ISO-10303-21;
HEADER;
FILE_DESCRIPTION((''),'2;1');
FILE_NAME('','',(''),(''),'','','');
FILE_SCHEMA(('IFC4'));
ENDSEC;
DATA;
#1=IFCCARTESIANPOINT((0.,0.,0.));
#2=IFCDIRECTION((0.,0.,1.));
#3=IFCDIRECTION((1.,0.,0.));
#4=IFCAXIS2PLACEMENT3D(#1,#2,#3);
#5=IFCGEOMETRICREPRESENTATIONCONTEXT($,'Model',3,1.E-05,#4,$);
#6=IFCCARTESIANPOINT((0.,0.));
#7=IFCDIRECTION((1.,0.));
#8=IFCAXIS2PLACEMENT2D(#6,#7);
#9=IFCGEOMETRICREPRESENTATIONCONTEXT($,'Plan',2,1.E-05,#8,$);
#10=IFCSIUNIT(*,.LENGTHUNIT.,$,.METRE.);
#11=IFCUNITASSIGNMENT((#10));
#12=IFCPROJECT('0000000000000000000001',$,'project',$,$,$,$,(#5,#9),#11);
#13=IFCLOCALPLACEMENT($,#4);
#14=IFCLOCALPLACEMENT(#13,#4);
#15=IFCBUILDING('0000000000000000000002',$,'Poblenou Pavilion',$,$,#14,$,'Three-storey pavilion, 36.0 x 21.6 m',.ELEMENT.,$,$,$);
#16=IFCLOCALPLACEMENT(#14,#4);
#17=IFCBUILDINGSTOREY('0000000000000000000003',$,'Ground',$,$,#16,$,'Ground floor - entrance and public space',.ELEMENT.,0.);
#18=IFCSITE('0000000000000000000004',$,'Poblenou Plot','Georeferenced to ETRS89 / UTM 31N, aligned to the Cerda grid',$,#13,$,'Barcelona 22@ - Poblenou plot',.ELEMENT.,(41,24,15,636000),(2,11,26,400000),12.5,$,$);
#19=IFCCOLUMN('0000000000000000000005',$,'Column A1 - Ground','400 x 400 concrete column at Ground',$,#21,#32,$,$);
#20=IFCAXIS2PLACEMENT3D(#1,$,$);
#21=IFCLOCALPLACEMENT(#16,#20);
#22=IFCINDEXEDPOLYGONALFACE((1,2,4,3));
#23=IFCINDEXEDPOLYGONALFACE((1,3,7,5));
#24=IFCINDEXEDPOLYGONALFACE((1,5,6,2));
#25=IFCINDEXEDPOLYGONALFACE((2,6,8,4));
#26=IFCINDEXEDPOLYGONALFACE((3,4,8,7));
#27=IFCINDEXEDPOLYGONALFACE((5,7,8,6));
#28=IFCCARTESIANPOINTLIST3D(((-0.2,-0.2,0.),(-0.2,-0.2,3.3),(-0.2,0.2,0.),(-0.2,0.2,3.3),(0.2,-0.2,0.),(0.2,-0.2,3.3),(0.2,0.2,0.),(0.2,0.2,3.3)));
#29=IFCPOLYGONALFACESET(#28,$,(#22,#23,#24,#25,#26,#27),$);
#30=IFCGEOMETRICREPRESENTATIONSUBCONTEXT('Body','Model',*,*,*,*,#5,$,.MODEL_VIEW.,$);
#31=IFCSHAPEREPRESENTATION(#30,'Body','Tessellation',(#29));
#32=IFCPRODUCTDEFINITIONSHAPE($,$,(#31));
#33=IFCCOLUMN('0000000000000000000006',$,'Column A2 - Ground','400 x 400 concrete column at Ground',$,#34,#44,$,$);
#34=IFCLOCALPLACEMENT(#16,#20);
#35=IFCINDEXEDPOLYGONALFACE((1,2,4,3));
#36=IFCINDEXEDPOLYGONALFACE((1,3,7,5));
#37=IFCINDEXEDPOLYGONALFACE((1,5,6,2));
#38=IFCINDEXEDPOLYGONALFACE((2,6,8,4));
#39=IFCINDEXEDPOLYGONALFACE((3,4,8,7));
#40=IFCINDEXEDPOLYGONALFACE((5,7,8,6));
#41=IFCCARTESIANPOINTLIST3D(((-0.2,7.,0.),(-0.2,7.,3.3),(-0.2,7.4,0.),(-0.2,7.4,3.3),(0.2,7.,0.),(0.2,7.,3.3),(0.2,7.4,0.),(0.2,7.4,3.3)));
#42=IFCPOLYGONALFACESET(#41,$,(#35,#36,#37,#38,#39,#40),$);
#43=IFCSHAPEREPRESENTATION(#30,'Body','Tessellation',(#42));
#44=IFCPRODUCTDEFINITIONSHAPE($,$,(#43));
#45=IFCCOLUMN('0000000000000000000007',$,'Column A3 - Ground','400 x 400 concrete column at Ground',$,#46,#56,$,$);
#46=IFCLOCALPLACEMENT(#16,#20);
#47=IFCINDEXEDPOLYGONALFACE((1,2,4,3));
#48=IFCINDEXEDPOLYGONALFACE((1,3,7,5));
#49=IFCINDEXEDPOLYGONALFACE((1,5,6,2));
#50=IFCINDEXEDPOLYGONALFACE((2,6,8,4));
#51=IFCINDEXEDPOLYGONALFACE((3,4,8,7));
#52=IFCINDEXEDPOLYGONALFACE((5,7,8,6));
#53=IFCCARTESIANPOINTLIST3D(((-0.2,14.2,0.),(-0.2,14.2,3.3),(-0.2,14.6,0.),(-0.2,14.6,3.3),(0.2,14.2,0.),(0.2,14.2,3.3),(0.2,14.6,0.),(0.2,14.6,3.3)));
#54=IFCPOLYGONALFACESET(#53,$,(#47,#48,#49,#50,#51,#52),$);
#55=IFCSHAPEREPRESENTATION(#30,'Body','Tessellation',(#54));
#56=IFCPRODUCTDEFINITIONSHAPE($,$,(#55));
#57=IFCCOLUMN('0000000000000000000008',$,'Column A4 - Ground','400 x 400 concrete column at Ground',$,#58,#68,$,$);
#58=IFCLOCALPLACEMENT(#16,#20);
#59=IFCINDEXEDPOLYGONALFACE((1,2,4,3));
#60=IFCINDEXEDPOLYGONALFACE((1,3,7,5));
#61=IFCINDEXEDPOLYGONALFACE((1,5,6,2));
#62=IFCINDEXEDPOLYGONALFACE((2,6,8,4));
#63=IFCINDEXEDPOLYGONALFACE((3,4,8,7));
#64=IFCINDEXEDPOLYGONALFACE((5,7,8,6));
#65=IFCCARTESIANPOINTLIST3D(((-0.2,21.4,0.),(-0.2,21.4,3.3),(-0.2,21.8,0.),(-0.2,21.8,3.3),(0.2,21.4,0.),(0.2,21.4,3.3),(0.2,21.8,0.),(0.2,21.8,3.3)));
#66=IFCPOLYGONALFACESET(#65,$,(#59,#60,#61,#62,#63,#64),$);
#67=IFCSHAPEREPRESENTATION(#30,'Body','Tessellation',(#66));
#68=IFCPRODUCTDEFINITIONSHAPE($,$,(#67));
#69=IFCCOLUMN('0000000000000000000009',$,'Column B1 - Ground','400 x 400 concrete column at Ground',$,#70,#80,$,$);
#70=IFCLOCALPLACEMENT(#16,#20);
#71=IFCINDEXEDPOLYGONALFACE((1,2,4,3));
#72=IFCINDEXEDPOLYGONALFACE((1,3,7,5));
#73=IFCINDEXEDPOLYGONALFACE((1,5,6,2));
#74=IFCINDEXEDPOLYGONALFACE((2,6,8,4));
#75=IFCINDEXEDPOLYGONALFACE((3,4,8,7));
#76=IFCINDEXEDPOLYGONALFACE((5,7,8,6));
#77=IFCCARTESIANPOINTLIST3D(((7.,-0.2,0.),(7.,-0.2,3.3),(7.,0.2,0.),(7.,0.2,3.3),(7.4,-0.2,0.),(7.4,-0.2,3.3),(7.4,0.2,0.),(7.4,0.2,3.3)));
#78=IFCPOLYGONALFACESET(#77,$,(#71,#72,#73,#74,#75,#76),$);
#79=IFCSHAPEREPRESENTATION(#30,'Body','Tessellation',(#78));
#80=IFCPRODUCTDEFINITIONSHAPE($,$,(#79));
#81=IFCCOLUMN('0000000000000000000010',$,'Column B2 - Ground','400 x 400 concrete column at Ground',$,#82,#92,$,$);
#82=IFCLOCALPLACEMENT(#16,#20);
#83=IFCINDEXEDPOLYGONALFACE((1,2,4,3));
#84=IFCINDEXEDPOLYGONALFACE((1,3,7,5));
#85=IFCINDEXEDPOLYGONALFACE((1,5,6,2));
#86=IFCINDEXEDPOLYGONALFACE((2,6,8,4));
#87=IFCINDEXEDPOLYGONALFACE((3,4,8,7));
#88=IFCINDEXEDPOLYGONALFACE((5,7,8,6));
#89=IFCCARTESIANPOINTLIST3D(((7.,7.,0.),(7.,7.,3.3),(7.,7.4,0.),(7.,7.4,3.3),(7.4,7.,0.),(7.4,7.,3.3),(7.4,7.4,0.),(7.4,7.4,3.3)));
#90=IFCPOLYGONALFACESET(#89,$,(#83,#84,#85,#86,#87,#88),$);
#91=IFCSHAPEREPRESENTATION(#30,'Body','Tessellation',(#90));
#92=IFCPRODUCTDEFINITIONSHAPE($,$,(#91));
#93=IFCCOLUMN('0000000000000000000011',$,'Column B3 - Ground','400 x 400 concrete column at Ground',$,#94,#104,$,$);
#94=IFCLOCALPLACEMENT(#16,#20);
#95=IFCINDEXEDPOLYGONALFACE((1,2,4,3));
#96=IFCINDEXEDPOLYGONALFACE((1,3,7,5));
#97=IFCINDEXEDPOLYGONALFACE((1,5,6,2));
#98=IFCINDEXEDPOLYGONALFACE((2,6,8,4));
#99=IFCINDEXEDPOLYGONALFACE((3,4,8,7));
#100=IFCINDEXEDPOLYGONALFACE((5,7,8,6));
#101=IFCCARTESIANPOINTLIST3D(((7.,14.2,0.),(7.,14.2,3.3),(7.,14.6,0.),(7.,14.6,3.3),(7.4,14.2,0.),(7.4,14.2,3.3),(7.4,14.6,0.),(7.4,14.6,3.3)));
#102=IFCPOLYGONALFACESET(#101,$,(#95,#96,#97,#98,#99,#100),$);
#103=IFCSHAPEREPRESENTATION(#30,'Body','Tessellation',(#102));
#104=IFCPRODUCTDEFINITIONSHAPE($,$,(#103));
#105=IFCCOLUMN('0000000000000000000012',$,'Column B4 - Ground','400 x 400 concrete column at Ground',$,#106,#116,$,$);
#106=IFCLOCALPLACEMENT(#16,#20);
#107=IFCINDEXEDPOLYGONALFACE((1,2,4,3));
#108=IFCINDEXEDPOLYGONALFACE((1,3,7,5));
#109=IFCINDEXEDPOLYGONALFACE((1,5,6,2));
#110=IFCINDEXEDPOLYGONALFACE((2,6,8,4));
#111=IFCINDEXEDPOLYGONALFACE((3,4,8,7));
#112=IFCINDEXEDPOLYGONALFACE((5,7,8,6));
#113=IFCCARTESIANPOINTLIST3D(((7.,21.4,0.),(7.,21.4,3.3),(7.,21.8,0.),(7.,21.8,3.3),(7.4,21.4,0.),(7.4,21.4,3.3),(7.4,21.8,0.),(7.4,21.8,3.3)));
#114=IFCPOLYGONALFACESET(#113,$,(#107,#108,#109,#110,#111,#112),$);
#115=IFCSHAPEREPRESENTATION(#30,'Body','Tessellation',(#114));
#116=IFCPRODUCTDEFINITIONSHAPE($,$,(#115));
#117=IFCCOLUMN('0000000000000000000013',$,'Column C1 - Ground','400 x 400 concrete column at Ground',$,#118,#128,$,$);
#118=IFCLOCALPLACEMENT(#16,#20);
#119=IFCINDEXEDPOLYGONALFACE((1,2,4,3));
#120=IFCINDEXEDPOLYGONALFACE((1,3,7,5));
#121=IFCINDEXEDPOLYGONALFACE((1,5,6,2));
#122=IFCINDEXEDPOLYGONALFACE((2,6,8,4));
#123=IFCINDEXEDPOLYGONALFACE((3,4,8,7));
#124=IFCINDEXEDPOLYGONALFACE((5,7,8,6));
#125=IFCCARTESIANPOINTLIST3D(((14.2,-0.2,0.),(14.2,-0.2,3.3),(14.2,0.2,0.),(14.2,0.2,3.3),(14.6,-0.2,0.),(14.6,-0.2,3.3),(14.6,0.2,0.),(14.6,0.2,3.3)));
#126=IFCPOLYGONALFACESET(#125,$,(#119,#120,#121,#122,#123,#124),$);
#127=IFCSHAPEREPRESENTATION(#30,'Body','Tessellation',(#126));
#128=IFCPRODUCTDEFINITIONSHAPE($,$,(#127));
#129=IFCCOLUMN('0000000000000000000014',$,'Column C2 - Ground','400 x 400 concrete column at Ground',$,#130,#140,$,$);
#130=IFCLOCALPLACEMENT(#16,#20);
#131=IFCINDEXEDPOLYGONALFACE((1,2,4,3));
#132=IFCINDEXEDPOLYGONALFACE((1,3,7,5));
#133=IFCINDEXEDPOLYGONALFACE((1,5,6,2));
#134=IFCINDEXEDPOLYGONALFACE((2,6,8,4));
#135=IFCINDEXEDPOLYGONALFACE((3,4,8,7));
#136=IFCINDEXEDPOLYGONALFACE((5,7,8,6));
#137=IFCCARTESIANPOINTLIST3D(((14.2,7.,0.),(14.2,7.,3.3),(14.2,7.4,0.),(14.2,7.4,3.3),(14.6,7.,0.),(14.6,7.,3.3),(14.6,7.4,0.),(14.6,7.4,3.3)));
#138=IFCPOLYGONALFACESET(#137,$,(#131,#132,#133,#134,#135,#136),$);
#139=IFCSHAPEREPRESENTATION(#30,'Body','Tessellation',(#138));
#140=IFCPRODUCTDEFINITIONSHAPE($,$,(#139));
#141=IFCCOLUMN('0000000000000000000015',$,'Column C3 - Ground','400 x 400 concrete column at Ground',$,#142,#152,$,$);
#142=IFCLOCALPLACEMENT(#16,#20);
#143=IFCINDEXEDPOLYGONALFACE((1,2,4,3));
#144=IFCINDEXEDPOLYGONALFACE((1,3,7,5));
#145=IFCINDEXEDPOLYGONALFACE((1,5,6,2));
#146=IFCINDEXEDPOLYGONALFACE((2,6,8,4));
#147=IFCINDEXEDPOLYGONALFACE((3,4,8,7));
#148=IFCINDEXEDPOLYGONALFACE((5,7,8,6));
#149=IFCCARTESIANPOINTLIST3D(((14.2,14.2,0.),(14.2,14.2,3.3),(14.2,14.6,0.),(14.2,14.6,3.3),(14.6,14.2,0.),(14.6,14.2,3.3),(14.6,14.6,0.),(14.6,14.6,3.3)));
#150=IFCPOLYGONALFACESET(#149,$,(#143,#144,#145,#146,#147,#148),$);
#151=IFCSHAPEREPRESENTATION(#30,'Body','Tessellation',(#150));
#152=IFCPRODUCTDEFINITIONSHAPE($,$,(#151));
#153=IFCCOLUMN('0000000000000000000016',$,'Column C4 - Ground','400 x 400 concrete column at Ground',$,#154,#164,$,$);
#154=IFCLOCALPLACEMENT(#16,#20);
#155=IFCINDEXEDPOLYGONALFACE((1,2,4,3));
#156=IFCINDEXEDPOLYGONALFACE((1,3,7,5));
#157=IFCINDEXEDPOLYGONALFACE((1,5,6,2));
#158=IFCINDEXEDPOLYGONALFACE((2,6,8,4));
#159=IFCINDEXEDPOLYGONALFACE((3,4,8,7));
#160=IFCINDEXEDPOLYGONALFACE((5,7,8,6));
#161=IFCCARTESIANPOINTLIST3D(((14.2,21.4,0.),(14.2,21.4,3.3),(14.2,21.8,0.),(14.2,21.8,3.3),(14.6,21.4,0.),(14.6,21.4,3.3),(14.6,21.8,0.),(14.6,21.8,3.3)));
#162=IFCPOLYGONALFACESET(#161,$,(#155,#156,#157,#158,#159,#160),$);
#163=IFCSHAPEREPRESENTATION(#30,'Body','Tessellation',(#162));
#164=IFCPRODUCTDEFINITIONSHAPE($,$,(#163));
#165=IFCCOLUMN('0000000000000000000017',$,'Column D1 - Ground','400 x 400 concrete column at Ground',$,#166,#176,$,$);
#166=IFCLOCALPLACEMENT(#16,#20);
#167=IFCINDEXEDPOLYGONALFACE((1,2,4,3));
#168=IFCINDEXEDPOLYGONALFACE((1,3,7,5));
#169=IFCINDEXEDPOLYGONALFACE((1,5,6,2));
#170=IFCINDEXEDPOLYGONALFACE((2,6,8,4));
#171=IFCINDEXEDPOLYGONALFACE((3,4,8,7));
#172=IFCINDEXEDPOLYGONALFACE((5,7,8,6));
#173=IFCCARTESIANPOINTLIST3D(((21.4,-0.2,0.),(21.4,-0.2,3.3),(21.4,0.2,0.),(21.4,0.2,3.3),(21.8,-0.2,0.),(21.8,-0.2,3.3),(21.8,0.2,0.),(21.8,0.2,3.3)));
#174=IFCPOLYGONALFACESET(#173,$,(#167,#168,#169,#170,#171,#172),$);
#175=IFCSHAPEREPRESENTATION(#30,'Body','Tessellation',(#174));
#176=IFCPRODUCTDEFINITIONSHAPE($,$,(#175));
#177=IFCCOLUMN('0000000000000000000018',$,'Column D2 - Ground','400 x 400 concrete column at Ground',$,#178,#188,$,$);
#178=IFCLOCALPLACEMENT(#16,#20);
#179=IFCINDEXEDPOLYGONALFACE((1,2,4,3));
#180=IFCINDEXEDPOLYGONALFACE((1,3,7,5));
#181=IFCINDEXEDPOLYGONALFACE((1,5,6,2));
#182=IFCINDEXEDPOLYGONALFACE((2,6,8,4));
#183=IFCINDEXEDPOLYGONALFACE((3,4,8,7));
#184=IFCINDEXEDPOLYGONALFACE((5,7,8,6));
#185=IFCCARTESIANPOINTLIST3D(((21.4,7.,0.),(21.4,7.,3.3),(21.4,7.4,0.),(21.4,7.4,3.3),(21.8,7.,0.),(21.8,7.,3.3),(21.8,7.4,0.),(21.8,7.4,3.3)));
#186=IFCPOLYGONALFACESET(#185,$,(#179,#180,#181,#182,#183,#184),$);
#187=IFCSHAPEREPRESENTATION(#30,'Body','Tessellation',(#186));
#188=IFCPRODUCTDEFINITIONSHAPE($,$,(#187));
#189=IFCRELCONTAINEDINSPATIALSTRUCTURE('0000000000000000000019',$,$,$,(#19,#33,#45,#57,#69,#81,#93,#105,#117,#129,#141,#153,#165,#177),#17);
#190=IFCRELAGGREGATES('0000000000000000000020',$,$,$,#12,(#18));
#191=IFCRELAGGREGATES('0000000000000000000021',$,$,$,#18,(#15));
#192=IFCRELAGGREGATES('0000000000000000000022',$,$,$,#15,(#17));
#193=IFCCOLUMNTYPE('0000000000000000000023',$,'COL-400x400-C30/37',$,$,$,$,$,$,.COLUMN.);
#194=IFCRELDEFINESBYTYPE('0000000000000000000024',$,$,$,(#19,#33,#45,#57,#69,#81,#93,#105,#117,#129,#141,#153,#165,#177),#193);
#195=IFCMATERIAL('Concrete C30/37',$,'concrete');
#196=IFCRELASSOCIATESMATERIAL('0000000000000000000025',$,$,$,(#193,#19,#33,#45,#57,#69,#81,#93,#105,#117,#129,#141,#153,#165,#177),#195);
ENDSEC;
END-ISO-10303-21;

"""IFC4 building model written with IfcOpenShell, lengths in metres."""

from ifc_helpers import new_model, si_unit, frame, origin_with_axes, origin_2d_with_axis, place, context, subcontext, project, spatial, line, indexed_curve, rectangle, outline, extrude, material, material_profile, profile_set, profile_usage, type_object, element, save


model = new_model("IFC4")

# Units and contexts
model_context = context("Model", 3, precision=1e-05, world=origin_with_axes())
plan_context = context("Plan", 2, precision=1e-05, world=origin_2d_with_axis())
body_context = subcontext(model_context, "Body", "Model", "MODEL_VIEW")
ifc_project = project(units=[si_unit("LENGTHUNIT", "METRE")], contexts=[model_context, plan_context])

# Site, building, storey
site_placement = place(None, origin_with_axes())
site = spatial("IfcSite", under=ifc_project, at=site_placement, Name="Poblenou Plot", Description="Georeferenced to ETRS89 / UTM 31N, aligned to the Cerda grid", LongName="Barcelona 22@ - Poblenou plot", CompositionType="ELEMENT", RefLatitude=(41, 24, 15, 636000), RefLongitude=(2, 11, 26, 400000), RefElevation=12.5)
building_placement = place(site_placement, origin_with_axes())
building = spatial("IfcBuilding", under=site, at=building_placement, Name="Poblenou Pavilion", LongName="Three-storey pavilion, 36.0 x 21.6 m", CompositionType="ELEMENT")
storey_placement = place(building_placement, origin_with_axes())
storey = spatial("IfcBuildingStorey", under=building, at=storey_placement, Name="Ground", LongName="Ground floor - entrance and public space", CompositionType="ELEMENT", Elevation=0.0)

# Columns
ifc_material = material(Name="Concrete C30/37", Category="concrete")
ifc_material_profile = material_profile(ifc_material, rectangle(XDim=0.4, YDim=0.4))
ifc_profile_set = profile_set([ifc_material_profile], Name="COL-400x400-C30/37")
ifc_profile_usage_1 = profile_usage(ifc_profile_set)
column_type = type_object("IfcColumnType", Name="COL-400x400-C30/37", PredefinedType="COLUMN", material=ifc_profile_set)
column_1_placement = place(storey_placement, frame((-0.2, -0.2, 0.0), z_axis=(0.0, 0.0, 1.0), x_axis=(1.0, 0.0, 0.0)))
element("IfcColumn", 1, at=column_1_placement, inside=storey, type_object=column_type, material=ifc_profile_usage_1, Name="Column A1 - Ground", Description="400 x 400 concrete column at Ground", context=body_context, shape_type="SweptSolid", body=[
    extrude(outline(indexed_curve([(0.0, 0.0), (0.4, 0.0), (0.4, 0.4), (0.0, 0.4)], segments=[line(1, 2, 3, 4, 1)])), origin_with_axes(), (0.0, 0.0, 1.0), 3.3),
])
ifc_profile_usage_2 = profile_usage(ifc_profile_set)
column_2_placement = place(storey_placement, frame((-0.2, 7.0, 0.0), z_axis=(0.0, 0.0, 1.0), x_axis=(1.0, 0.0, 0.0)))
element("IfcColumn", 2, at=column_2_placement, inside=storey, type_object=column_type, material=ifc_profile_usage_2, Name="Column A2 - Ground", Description="400 x 400 concrete column at Ground", context=body_context, shape_type="SweptSolid", body=[
    extrude(outline(indexed_curve([(0.0, 0.0), (0.4, 0.0), (0.4, 0.4), (0.0, 0.4)], segments=[line(1, 2, 3, 4, 1)])), origin_with_axes(), (0.0, 0.0, 1.0), 3.3),
])
ifc_profile_usage_3 = profile_usage(ifc_profile_set)
column_3_placement = place(storey_placement, frame((-0.2, 14.2, 0.0), z_axis=(0.0, 0.0, 1.0), x_axis=(1.0, 0.0, 0.0)))
element("IfcColumn", 3, at=column_3_placement, inside=storey, type_object=column_type, material=ifc_profile_usage_3, Name="Column A3 - Ground", Description="400 x 400 concrete column at Ground", context=body_context, shape_type="SweptSolid", body=[
    extrude(outline(indexed_curve([(0.0, 0.0), (0.4, 0.0), (0.4, 0.4), (0.0, 0.4)], segments=[line(1, 2, 3, 4, 1)])), origin_with_axes(), (0.0, 0.0, 1.0), 3.3),
])
ifc_profile_usage_4 = profile_usage(ifc_profile_set)
column_4_placement = place(storey_placement, frame((-0.2, 21.4, 0.0), z_axis=(0.0, 0.0, 1.0), x_axis=(1.0, 0.0, 0.0)))
element("IfcColumn", 4, at=column_4_placement, inside=storey, type_object=column_type, material=ifc_profile_usage_4, Name="Column A4 - Ground", Description="400 x 400 concrete column at Ground", context=body_context, shape_type="SweptSolid", body=[
    extrude(outline(indexed_curve([(0.0, 0.0), (0.4, 0.0), (0.4, 0.4), (0.0, 0.4)], segments=[line(1, 2, 3, 4, 1)])), origin_with_axes(), (0.0, 0.0, 1.0), 3.3),
])
ifc_profile_usage_5 = profile_usage(ifc_profile_set)
column_5_placement = place(storey_placement, frame((7.0, -0.2, 0.0), z_axis=(0.0, 0.0, 1.0), x_axis=(1.0, 0.0, 0.0)))
element("IfcColumn", 5, at=column_5_placement, inside=storey, type_object=column_type, material=ifc_profile_usage_5, Name="Column B1 - Ground", Description="400 x 400 concrete column at Ground", context=body_context, shape_type="SweptSolid", body=[
    extrude(outline(indexed_curve([(0.0, 0.0), (0.4, 0.0), (0.4, 0.4), (0.0, 0.4)], segments=[line(1, 2, 3, 4, 1)])), origin_with_axes(), (0.0, 0.0, 1.0), 3.3),
])
ifc_profile_usage_6 = profile_usage(ifc_profile_set)
column_6_placement = place(storey_placement, frame((7.0, 7.0, 0.0), z_axis=(0.0, 0.0, 1.0), x_axis=(1.0, 0.0, 0.0)))
element("IfcColumn", 6, at=column_6_placement, inside=storey, type_object=column_type, material=ifc_profile_usage_6, Name="Column B2 - Ground", Description="400 x 400 concrete column at Ground", context=body_context, shape_type="SweptSolid", body=[
    extrude(outline(indexed_curve([(0.0, 0.0), (0.4, 0.0), (0.4, 0.4), (0.0, 0.4)], segments=[line(1, 2, 3, 4, 1)])), origin_with_axes(), (0.0, 0.0, 1.0), 3.3),
])
ifc_profile_usage_7 = profile_usage(ifc_profile_set)
column_7_placement = place(storey_placement, frame((7.0, 14.2, 0.0), z_axis=(0.0, 0.0, 1.0), x_axis=(1.0, 0.0, 0.0)))
element("IfcColumn", 7, at=column_7_placement, inside=storey, type_object=column_type, material=ifc_profile_usage_7, Name="Column B3 - Ground", Description="400 x 400 concrete column at Ground", context=body_context, shape_type="SweptSolid", body=[
    extrude(outline(indexed_curve([(0.0, 0.0), (0.4, 0.0), (0.4, 0.4), (0.0, 0.4)], segments=[line(1, 2, 3, 4, 1)])), origin_with_axes(), (0.0, 0.0, 1.0), 3.3),
])
ifc_profile_usage_8 = profile_usage(ifc_profile_set)
column_8_placement = place(storey_placement, frame((7.0, 21.4, 0.0), z_axis=(0.0, 0.0, 1.0), x_axis=(1.0, 0.0, 0.0)))
element("IfcColumn", 8, at=column_8_placement, inside=storey, type_object=column_type, material=ifc_profile_usage_8, Name="Column B4 - Ground", Description="400 x 400 concrete column at Ground", context=body_context, shape_type="SweptSolid", body=[
    extrude(outline(indexed_curve([(0.0, 0.0), (0.4, 0.0), (0.4, 0.4), (0.0, 0.4)], segments=[line(1, 2, 3, 4, 1)])), origin_with_axes(), (0.0, 0.0, 1.0), 3.3),
])
ifc_profile_usage_9 = profile_usage(ifc_profile_set)
column_9_placement = place(storey_placement, frame((14.2, -0.2, 0.0), z_axis=(0.0, 0.0, 1.0), x_axis=(1.0, 0.0, 0.0)))
element("IfcColumn", 9, at=column_9_placement, inside=storey, type_object=column_type, material=ifc_profile_usage_9, Name="Column C1 - Ground", Description="400 x 400 concrete column at Ground", context=body_context, shape_type="SweptSolid", body=[
    extrude(outline(indexed_curve([(0.0, 0.0), (0.4, 0.0), (0.4, 0.4), (0.0, 0.4)], segments=[line(1, 2, 3, 4, 1)])), origin_with_axes(), (0.0, 0.0, 1.0), 3.3),
])
ifc_profile_usage_10 = profile_usage(ifc_profile_set)
column_10_placement = place(storey_placement, frame((14.2, 7.0, 0.0), z_axis=(0.0, 0.0, 1.0), x_axis=(1.0, 0.0, 0.0)))
element("IfcColumn", 10, at=column_10_placement, inside=storey, type_object=column_type, material=ifc_profile_usage_10, Name="Column C2 - Ground", Description="400 x 400 concrete column at Ground", context=body_context, shape_type="SweptSolid", body=[
    extrude(outline(indexed_curve([(0.0, 0.0), (0.4, 0.0), (0.4, 0.4), (0.0, 0.4)], segments=[line(1, 2, 3, 4, 1)])), origin_with_axes(), (0.0, 0.0, 1.0), 3.3),
])
ifc_profile_usage_11 = profile_usage(ifc_profile_set)
column_11_placement = place(storey_placement, frame((14.2, 14.2, 0.0), z_axis=(0.0, 0.0, 1.0), x_axis=(1.0, 0.0, 0.0)))
element("IfcColumn", 11, at=column_11_placement, inside=storey, type_object=column_type, material=ifc_profile_usage_11, Name="Column C3 - Ground", Description="400 x 400 concrete column at Ground", context=body_context, shape_type="SweptSolid", body=[
    extrude(outline(indexed_curve([(0.0, 0.0), (0.4, 0.0), (0.4, 0.4), (0.0, 0.4)], segments=[line(1, 2, 3, 4, 1)])), origin_with_axes(), (0.0, 0.0, 1.0), 3.3),
])
ifc_profile_usage_12 = profile_usage(ifc_profile_set)
column_12_placement = place(storey_placement, frame((14.2, 21.4, 0.0), z_axis=(0.0, 0.0, 1.0), x_axis=(1.0, 0.0, 0.0)))
element("IfcColumn", 12, at=column_12_placement, inside=storey, type_object=column_type, material=ifc_profile_usage_12, Name="Column C4 - Ground", Description="400 x 400 concrete column at Ground", context=body_context, shape_type="SweptSolid", body=[
    extrude(outline(indexed_curve([(0.0, 0.0), (0.4, 0.0), (0.4, 0.4), (0.0, 0.4)], segments=[line(1, 2, 3, 4, 1)])), origin_with_axes(), (0.0, 0.0, 1.0), 3.3),
])
ifc_profile_usage_13 = profile_usage(ifc_profile_set)
column_13_placement = place(storey_placement, frame((21.4, -0.2, 0.0), z_axis=(0.0, 0.0, 1.0), x_axis=(1.0, 0.0, 0.0)))
element("IfcColumn", 13, at=column_13_placement, inside=storey, type_object=column_type, material=ifc_profile_usage_13, Name="Column D1 - Ground", Description="400 x 400 concrete column at Ground", context=body_context, shape_type="SweptSolid", body=[
    extrude(outline(indexed_curve([(0.0, 0.0), (0.4, 0.0), (0.4, 0.4), (0.0, 0.4)], segments=[line(1, 2, 3, 4, 1)])), origin_with_axes(), (0.0, 0.0, 1.0), 3.3),
])
ifc_profile_usage_14 = profile_usage(ifc_profile_set)
column_14_placement = place(storey_placement, frame((21.4, 7.0, 0.0), z_axis=(0.0, 0.0, 1.0), x_axis=(1.0, 0.0, 0.0)))
element("IfcColumn", 14, at=column_14_placement, inside=storey, type_object=column_type, material=ifc_profile_usage_14, Name="Column D2 - Ground", Description="400 x 400 concrete column at Ground", context=body_context, shape_type="SweptSolid", body=[
    extrude(outline(indexed_curve([(0.0, 0.0), (0.4, 0.0), (0.4, 0.4), (0.0, 0.4)], segments=[line(1, 2, 3, 4, 1)])), origin_with_axes(), (0.0, 0.0, 1.0), 3.3),
])

save(model, "model.ifc")
